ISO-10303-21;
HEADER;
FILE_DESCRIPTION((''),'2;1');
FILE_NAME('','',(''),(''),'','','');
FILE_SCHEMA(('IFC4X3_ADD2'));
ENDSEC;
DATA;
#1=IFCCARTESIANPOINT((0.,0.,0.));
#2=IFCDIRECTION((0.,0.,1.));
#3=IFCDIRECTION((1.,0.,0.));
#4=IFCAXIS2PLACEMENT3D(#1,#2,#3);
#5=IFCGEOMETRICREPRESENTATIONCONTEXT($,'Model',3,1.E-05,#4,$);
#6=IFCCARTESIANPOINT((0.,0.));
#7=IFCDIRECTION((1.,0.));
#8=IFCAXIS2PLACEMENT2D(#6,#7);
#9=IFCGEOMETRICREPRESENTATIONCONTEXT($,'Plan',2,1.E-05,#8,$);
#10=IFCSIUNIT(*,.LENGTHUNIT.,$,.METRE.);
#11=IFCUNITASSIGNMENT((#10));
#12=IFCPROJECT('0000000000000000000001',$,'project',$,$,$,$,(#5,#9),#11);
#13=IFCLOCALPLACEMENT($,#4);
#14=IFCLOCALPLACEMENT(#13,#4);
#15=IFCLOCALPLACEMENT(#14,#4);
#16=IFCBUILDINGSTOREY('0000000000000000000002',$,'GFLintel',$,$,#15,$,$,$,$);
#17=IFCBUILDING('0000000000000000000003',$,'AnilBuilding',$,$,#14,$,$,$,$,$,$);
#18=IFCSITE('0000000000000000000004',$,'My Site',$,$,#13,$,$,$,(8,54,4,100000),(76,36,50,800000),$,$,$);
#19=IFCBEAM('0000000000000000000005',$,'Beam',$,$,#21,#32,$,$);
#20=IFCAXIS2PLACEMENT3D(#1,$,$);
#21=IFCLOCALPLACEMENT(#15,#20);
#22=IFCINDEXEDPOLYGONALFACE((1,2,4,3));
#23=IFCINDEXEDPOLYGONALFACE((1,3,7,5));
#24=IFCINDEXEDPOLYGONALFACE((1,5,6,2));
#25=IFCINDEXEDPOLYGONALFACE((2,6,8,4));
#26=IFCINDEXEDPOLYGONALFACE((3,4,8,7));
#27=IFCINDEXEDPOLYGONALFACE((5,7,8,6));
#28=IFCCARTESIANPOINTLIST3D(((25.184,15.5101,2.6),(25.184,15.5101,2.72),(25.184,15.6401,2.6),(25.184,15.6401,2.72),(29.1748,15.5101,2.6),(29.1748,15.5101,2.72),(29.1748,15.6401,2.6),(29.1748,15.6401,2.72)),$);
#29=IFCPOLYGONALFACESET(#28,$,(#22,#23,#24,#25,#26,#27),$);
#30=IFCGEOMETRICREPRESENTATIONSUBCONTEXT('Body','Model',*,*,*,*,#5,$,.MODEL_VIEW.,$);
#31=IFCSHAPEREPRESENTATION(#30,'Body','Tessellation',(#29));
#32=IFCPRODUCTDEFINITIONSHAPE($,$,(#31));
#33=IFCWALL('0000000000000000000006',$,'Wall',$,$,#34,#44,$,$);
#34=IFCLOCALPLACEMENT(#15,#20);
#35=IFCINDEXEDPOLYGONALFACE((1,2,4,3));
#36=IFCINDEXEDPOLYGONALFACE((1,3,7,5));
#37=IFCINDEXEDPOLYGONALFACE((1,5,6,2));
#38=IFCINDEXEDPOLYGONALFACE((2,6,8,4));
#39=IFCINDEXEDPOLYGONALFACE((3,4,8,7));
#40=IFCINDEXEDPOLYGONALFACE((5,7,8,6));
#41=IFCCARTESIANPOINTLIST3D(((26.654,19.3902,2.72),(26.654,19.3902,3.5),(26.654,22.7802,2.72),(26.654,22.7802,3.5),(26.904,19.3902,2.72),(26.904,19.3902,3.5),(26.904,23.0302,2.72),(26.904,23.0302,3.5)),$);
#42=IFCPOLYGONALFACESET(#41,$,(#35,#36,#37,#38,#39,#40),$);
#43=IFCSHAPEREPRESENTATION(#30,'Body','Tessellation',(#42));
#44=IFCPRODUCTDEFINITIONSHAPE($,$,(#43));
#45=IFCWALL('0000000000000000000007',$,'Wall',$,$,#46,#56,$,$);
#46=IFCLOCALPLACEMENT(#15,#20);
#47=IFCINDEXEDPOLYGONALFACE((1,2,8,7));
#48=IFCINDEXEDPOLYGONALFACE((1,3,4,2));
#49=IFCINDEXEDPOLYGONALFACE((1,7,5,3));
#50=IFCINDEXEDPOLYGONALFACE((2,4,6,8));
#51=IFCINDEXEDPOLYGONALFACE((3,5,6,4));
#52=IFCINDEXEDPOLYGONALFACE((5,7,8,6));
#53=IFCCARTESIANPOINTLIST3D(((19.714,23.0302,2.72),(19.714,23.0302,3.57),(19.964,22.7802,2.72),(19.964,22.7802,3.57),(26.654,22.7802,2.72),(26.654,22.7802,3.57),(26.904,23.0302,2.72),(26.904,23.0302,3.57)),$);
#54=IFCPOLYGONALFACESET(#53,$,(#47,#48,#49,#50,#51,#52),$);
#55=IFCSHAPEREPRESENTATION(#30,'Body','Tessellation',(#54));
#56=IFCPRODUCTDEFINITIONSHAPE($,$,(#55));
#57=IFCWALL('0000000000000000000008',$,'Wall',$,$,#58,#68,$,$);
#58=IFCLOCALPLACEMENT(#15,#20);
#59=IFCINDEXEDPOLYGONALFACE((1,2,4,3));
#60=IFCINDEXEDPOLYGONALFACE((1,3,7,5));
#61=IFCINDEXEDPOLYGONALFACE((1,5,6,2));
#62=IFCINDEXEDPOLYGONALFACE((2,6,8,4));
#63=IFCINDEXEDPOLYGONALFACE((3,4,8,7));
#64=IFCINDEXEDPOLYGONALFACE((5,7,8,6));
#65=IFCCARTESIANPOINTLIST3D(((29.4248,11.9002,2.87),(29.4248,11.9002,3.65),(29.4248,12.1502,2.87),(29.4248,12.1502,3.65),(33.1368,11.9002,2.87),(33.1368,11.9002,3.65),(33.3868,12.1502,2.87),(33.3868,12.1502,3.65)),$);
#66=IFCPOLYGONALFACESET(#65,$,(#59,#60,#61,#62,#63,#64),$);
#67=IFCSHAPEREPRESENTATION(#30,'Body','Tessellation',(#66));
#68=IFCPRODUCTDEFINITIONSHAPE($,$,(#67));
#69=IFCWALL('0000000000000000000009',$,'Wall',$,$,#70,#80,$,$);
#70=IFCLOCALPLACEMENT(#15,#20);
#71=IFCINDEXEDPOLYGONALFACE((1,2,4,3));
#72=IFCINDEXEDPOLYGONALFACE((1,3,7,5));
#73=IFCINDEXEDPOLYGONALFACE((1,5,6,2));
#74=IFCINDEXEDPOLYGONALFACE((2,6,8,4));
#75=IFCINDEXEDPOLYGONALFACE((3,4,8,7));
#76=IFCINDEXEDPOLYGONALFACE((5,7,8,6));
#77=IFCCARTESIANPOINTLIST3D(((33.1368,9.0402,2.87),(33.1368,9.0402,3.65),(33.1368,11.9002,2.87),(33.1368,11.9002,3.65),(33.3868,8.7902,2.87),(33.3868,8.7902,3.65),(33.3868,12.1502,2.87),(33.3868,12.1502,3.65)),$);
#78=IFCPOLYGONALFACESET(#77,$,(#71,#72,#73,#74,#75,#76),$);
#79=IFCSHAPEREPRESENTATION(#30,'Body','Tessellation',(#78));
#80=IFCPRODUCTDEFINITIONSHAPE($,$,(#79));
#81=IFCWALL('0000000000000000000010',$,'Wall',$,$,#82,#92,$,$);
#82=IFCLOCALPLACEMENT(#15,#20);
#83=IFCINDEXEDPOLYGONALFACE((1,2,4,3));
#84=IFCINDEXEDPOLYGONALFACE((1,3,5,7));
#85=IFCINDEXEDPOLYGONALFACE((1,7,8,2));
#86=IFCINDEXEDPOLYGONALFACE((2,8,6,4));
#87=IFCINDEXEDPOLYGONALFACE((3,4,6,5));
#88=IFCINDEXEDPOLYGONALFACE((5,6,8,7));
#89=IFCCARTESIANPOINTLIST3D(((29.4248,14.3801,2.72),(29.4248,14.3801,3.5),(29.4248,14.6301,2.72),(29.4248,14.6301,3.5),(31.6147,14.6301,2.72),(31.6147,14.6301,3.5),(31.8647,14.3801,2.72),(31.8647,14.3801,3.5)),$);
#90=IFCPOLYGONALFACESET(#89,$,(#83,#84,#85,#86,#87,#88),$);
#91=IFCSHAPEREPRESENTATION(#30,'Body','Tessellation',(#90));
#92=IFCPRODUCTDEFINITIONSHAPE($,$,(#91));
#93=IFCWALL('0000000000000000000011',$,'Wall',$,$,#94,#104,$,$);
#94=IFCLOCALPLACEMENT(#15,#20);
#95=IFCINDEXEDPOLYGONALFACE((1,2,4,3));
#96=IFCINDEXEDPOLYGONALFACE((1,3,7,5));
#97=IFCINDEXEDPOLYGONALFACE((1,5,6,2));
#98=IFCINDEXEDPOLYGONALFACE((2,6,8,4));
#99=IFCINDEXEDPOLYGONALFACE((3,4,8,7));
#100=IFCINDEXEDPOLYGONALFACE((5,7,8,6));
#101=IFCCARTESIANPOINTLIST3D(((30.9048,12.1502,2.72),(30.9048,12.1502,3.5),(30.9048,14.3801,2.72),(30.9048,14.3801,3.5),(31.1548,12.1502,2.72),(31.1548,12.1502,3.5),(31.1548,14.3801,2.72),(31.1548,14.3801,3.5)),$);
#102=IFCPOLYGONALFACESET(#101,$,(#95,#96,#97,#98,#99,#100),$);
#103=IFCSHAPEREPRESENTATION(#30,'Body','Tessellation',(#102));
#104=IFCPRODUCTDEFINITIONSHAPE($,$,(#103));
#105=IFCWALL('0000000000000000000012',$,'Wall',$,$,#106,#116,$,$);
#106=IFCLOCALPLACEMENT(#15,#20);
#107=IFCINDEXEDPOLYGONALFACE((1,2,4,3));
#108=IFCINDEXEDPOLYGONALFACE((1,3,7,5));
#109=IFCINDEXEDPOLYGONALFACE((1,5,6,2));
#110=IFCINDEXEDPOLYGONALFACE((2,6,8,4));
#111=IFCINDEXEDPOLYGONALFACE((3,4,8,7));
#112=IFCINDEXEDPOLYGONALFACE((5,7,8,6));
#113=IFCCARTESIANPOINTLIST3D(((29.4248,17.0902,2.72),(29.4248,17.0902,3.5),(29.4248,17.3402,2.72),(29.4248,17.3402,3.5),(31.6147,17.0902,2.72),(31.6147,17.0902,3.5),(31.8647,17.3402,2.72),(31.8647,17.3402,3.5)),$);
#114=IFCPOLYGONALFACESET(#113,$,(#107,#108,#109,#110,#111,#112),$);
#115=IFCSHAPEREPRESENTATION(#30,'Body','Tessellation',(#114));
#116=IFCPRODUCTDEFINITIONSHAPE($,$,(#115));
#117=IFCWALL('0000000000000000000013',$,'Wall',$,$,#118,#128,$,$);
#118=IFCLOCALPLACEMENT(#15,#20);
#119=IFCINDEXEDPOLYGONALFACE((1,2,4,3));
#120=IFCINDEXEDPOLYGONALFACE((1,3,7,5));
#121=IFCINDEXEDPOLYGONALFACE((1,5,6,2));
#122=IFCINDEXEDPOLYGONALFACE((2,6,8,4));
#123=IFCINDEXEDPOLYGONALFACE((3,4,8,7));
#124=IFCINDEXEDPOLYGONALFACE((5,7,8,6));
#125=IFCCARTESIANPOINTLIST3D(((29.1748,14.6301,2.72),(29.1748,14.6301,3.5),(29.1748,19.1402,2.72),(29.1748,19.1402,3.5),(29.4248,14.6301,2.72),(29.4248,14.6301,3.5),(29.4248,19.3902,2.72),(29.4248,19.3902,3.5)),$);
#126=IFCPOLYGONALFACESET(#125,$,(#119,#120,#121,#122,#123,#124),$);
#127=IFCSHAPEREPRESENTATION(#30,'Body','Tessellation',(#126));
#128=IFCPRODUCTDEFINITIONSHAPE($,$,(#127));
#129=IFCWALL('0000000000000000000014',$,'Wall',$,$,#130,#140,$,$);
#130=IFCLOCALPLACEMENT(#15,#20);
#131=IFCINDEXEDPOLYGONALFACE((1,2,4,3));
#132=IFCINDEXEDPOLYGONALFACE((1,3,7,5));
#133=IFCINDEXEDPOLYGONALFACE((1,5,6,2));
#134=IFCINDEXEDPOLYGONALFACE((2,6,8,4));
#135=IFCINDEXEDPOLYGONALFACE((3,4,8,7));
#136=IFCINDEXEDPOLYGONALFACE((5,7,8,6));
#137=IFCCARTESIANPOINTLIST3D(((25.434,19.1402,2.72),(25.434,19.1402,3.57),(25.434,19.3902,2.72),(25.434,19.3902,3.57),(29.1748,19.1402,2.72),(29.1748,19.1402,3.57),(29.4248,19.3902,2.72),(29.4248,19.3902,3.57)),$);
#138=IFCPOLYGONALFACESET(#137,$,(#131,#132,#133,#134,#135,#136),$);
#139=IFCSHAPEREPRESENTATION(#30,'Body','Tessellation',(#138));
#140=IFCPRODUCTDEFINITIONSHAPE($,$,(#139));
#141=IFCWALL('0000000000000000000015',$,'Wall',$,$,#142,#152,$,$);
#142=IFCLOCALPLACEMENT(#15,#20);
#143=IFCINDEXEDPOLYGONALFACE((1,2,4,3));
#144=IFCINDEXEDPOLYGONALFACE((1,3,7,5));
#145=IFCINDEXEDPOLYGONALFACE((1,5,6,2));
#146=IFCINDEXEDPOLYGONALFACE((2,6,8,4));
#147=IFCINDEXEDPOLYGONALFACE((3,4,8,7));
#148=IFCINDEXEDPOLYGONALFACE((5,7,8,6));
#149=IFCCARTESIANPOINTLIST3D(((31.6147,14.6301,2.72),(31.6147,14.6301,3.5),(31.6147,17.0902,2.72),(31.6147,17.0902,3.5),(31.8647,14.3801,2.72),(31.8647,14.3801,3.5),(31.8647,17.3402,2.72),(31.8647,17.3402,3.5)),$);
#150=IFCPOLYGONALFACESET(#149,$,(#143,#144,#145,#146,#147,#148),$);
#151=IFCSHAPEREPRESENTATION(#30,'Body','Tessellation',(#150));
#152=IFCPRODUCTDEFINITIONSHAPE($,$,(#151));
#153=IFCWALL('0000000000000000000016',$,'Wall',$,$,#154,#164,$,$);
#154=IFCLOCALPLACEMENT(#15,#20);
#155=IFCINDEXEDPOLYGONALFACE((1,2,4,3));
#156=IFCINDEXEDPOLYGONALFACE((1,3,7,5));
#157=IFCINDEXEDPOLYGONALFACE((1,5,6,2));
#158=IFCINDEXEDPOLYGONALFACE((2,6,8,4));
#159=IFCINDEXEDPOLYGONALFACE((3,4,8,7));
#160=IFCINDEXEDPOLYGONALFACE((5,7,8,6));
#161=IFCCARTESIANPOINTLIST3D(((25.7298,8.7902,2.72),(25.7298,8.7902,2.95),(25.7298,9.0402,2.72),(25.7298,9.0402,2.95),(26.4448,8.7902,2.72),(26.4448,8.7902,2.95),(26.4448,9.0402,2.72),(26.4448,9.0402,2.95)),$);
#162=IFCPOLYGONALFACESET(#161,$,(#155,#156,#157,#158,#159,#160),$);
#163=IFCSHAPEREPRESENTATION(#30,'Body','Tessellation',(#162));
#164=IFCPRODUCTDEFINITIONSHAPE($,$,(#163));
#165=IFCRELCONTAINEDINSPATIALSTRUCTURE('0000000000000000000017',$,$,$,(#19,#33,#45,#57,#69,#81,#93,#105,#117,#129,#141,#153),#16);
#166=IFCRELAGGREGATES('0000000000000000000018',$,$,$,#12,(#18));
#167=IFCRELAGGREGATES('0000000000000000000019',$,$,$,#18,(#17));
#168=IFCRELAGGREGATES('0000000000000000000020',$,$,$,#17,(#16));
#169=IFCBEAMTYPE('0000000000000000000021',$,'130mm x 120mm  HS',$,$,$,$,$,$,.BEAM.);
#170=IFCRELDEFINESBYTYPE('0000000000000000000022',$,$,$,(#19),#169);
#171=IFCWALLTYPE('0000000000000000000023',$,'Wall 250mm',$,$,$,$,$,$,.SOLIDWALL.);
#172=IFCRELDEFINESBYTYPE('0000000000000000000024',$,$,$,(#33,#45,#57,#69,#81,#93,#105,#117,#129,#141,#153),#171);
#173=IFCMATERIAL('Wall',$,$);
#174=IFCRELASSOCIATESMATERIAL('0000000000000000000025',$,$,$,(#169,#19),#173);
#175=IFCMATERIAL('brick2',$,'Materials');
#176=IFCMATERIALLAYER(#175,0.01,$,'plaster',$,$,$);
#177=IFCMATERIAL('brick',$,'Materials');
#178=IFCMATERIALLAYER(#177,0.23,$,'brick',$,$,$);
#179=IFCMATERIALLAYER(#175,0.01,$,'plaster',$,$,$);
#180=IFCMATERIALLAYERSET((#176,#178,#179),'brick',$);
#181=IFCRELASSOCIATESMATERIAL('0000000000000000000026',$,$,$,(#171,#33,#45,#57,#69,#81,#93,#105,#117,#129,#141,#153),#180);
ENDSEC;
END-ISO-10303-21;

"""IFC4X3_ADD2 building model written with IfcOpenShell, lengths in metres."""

from ifc_helpers import new_model, si_unit, frame, origin_with_axes, origin_2d_with_axis, place, context, subcontext, project, spatial, line, indexed_curve, rectangle, outline, extrude, material, layer, layer_set, layer_usage, material_profile, profile_set, profile_usage, type_object, element, save


model = new_model("IFC4X3_ADD2")

# Units and contexts
model_context = context("Model", 3, precision=1e-05, world=origin_with_axes())
plan_context = context("Plan", 2, precision=1e-05, world=origin_2d_with_axis())
body_context = subcontext(model_context, "Body", "Model", "MODEL_VIEW")
ifc_project = project(units=[si_unit("LENGTHUNIT", "METRE")], contexts=[model_context, plan_context])

# Site, building, storey
site_placement = place(None, origin_with_axes())
site = spatial("IfcSite", under=ifc_project, at=site_placement, Name="My Site", RefLatitude=(8, 54, 4, 100000), RefLongitude=(76, 36, 50, 800000))
building_placement = place(site_placement, origin_with_axes())
building = spatial("IfcBuilding", under=site, at=building_placement, Name="AnilBuilding")
storey_placement = place(building_placement, origin_with_axes())
storey = spatial("IfcBuildingStorey", under=building, at=storey_placement, Name="GFLintel")

# Beam
ifc_material_1 = material(Name="Wall")
ifc_material_profile_1 = material_profile(ifc_material_1, rectangle(XDim=0.13, YDim=0.12))
ifc_profile_set_1 = profile_set([ifc_material_profile_1], Name="concrete")
beam_type_1 = type_object("IfcBeamType", Name="130mm x 120mm  HS", PredefinedType="BEAM", material=ifc_profile_set_1)
ifc_profile_usage_1 = profile_usage(ifc_profile_set_1)
beam_1_placement = place(storey_placement, frame((29.1748, 15.5751, 2.66), z_axis=(-1.0, 0.000001, 0.0), x_axis=(-0.000001, -1.0, 0.0)))
element("IfcBeam", 1, at=beam_1_placement, inside=storey, type_object=beam_type_1, material=ifc_profile_usage_1, Name="Beam", context=body_context, shape_type="SweptSolid", body=[
    extrude(rectangle(XDim=0.13, YDim=0.12), origin_with_axes(), (0.0, 0.0, 1.0), 3.9908),
])

# Walls
ifc_material_2 = material(Name="brick2", Category="Materials")
ifc_layer_1 = layer(ifc_material_2, 0.01, Name="plaster")
ifc_material_3 = material(Name="brick", Category="Materials")
ifc_layer_2 = layer(ifc_material_3, 0.23, Name="brick")
ifc_layer_3 = layer(ifc_material_2, 0.01, Name="plaster")
ifc_layer_set_1 = layer_set([ifc_layer_1, ifc_layer_2, ifc_layer_3], Name="brick")
ifc_layer_usage_1 = layer_usage(ifc_layer_set_1, "AXIS2", "POSITIVE", 0.0)
wall_type_1 = type_object("IfcWallType", Name="Wall 250mm", PredefinedType="SOLIDWALL", material=ifc_layer_set_1)
wall_1_placement = place(storey_placement, frame((26.904, 19.3902, 2.72), z_axis=(0.0, 0.0, 1.0), x_axis=(0.000001, 1.0, 0.0)))
element("IfcWall", 2, at=wall_1_placement, inside=storey, type_object=wall_type_1, material=ifc_layer_usage_1, Name="Wall", context=body_context, shape_type="SweptSolid", body=[
    extrude(outline(indexed_curve([(0.0, 0.0), (0.0, 0.25), (3.39, 0.25), (3.64, 0.0)], segments=[line(1, 2, 3, 4, 1)])), origin_with_axes(), (0.0, 0.0, 1.0), 0.78),
])
ifc_layer_usage_2 = layer_usage(ifc_layer_set_1, "AXIS2", "POSITIVE", 0.0)
wall_2_placement = place(storey_placement, frame((26.904, 23.0302, 2.72), z_axis=(0.0, 0.0, 1.0), x_axis=(-1.0, 0.0, 0.0)))
element("IfcWall", 3, at=wall_2_placement, inside=storey, type_object=wall_type_1, material=ifc_layer_usage_2, Name="Wall", context=body_context, shape_type="SweptSolid", body=[
    extrude(outline(indexed_curve([(0.0, 0.0), (0.25, 0.25), (6.94, 0.25), (7.19, 0.0)], segments=[line(1, 2, 3, 4, 1)])), origin_with_axes(), (0.0, 0.0, 1.0), 0.85),
])
ifc_layer_usage_3 = layer_usage(ifc_layer_set_1, "AXIS2", "POSITIVE", 0.0)
wall_3_placement = place(storey_placement, frame((33.3868, 12.1502, 2.87), z_axis=(0.0, 0.0, 1.0), x_axis=(-1.0, 0.0, 0.0)))
element("IfcWall", 4, at=wall_3_placement, inside=storey, type_object=wall_type_1, material=ifc_layer_usage_3, Name="Wall", context=body_context, shape_type="SweptSolid", body=[
    extrude(outline(indexed_curve([(0.0, 0.0), (0.25, 0.25), (3.962, 0.25), (3.962, 0.0)], segments=[line(1, 2, 3, 4, 1)])), origin_with_axes(), (0.0, 0.0, 1.0), 0.78),
])
ifc_layer_usage_4 = layer_usage(ifc_layer_set_1, "AXIS2", "POSITIVE", 0.0)
wall_4_placement = place(storey_placement, frame((33.3868, 8.7902, 2.87), z_axis=(0.0, 0.0, 1.0), x_axis=(0.000001, 1.0, 0.0)))
element("IfcWall", 5, at=wall_4_placement, inside=storey, type_object=wall_type_1, material=ifc_layer_usage_4, Name="Wall", context=body_context, shape_type="SweptSolid", body=[
    extrude(outline(indexed_curve([(0.0, 0.0), (0.25, 0.25), (3.11, 0.25), (3.36, 0.0)], segments=[line(1, 2, 3, 4, 1)])), origin_with_axes(), (0.0, 0.0, 1.0), 0.78),
])
ifc_layer_usage_5 = layer_usage(ifc_layer_set_1, "AXIS2", "NEGATIVE", 0.0)
wall_5_placement = place(storey_placement, frame((31.8647, 14.3801, 2.72), z_axis=(0.0, 0.0, 1.0), x_axis=(-1.0, 0.0, 0.0)))
element("IfcWall", 6, at=wall_5_placement, inside=storey, type_object=wall_type_1, material=ifc_layer_usage_5, Name="Wall", context=body_context, shape_type="SweptSolid", body=[
    extrude(outline(indexed_curve([(0.25, -0.25), (0.0, 0.0), (2.44, 0.0), (2.44, -0.25)], segments=[line(1, 2, 3, 4, 1)])), origin_with_axes(), (0.0, 0.0, 1.0), 0.78),
])
ifc_layer_usage_6 = layer_usage(ifc_layer_set_1, "AXIS2", "POSITIVE", 0.0)
wall_6_placement = place(storey_placement, frame((31.1548, 12.1502, 2.72), z_axis=(0.0, 0.0, 1.0), x_axis=(0.000001, 1.0, 0.0)))
element("IfcWall", 7, at=wall_6_placement, inside=storey, type_object=wall_type_1, material=ifc_layer_usage_6, Name="Wall", context=body_context, shape_type="SweptSolid", body=[
    extrude(outline(indexed_curve([(0.0, 0.0), (0.0, 0.25), (2.2299, 0.25), (2.2299, 0.0)], segments=[line(1, 2, 3, 4, 1)])), origin_with_axes(), (0.0, 0.0, 1.0), 0.78),
])
ifc_layer_usage_7 = layer_usage(ifc_layer_set_1, "AXIS2", "POSITIVE", 0.0)
wall_7_placement = place(storey_placement, frame((31.8647, 17.3402, 2.72), z_axis=(0.0, 0.0, 1.0), x_axis=(-1.0, 0.0, 0.0)))
element("IfcWall", 8, at=wall_7_placement, inside=storey, type_object=wall_type_1, material=ifc_layer_usage_7, Name="Wall", context=body_context, shape_type="SweptSolid", body=[
    extrude(outline(indexed_curve([(0.0, 0.0), (0.25, 0.25), (2.44, 0.25), (2.44, 0.0)], segments=[line(1, 2, 3, 4, 1)])), origin_with_axes(), (0.0, 0.0, 1.0), 0.78),
])
ifc_layer_usage_8 = layer_usage(ifc_layer_set_1, "AXIS2", "POSITIVE", 0.0)
wall_8_placement = place(storey_placement, frame((29.4248, 14.6301, 2.72), z_axis=(0.0, 0.0, 1.0), x_axis=(0.000001, 1.0, 0.0)))
element("IfcWall", 9, at=wall_8_placement, inside=storey, type_object=wall_type_1, material=ifc_layer_usage_8, Name="Wall", context=body_context, shape_type="SweptSolid", body=[
    extrude(outline(indexed_curve([(0.0, 0.0), (0.0, 0.25), (4.5101, 0.25), (4.7601, 0.0)], segments=[line(1, 2, 3, 4, 1)])), origin_with_axes(), (0.0, 0.0, 1.0), 0.78),
])
ifc_layer_usage_9 = layer_usage(ifc_layer_set_1, "AXIS2", "POSITIVE", 0.0)
wall_9_placement = place(storey_placement, frame((29.4248, 19.3902, 2.72), z_axis=(0.0, 0.0, 1.0), x_axis=(-1.0, 0.0, 0.0)))
element("IfcWall", 10, at=wall_9_placement, inside=storey, type_object=wall_type_1, material=ifc_layer_usage_9, Name="Wall", context=body_context, shape_type="SweptSolid", body=[
    extrude(outline(indexed_curve([(0.0, 0.0), (0.25, 0.25), (3.9908, 0.25), (3.9908, 0.0)], segments=[line(1, 2, 3, 4, 1)])), origin_with_axes(), (0.0, 0.0, 1.0), 0.85),
])
ifc_layer_usage_10 = layer_usage(ifc_layer_set_1, "AXIS2", "POSITIVE", 0.0)
wall_10_placement = place(storey_placement, frame((31.8647, 14.3801, 2.72), z_axis=(0.0, 0.0, 1.0), x_axis=(0.000001, 1.0, 0.0)))
element("IfcWall", 11, at=wall_10_placement, inside=storey, type_object=wall_type_1, material=ifc_layer_usage_10, Name="Wall", context=body_context, shape_type="SweptSolid", body=[
    extrude(outline(indexed_curve([(0.0, 0.0), (0.25, 0.25), (2.71, 0.25), (2.96, 0.0)], segments=[line(1, 2, 3, 4, 1)])), origin_with_axes(), (0.0, 0.0, 1.0), 0.78),
])
ifc_layer_usage_11 = layer_usage(ifc_layer_set_1, "AXIS2", "NEGATIVE", 0.0)
wall_11_placement = place(storey_placement, frame((26.4448, 8.7902, 2.72), z_axis=(0.0, 0.0, 1.0), x_axis=(-1.0, 0.0, 0.0)))
element("IfcWall", 12, at=wall_11_placement, inside=storey, type_object=wall_type_1, material=ifc_layer_usage_11, Name="Wall", context=body_context, shape_type="SweptSolid", body=[
    extrude(outline(indexed_curve([(0.0, -0.25), (0.0, 0.0), (0.715, 0.0), (0.715, -0.25)], segments=[line(1, 2, 3, 4, 1)])), origin_with_axes(), (0.0, 0.0, 1.0), 0.23),
])

save(model, "model.ifc")
